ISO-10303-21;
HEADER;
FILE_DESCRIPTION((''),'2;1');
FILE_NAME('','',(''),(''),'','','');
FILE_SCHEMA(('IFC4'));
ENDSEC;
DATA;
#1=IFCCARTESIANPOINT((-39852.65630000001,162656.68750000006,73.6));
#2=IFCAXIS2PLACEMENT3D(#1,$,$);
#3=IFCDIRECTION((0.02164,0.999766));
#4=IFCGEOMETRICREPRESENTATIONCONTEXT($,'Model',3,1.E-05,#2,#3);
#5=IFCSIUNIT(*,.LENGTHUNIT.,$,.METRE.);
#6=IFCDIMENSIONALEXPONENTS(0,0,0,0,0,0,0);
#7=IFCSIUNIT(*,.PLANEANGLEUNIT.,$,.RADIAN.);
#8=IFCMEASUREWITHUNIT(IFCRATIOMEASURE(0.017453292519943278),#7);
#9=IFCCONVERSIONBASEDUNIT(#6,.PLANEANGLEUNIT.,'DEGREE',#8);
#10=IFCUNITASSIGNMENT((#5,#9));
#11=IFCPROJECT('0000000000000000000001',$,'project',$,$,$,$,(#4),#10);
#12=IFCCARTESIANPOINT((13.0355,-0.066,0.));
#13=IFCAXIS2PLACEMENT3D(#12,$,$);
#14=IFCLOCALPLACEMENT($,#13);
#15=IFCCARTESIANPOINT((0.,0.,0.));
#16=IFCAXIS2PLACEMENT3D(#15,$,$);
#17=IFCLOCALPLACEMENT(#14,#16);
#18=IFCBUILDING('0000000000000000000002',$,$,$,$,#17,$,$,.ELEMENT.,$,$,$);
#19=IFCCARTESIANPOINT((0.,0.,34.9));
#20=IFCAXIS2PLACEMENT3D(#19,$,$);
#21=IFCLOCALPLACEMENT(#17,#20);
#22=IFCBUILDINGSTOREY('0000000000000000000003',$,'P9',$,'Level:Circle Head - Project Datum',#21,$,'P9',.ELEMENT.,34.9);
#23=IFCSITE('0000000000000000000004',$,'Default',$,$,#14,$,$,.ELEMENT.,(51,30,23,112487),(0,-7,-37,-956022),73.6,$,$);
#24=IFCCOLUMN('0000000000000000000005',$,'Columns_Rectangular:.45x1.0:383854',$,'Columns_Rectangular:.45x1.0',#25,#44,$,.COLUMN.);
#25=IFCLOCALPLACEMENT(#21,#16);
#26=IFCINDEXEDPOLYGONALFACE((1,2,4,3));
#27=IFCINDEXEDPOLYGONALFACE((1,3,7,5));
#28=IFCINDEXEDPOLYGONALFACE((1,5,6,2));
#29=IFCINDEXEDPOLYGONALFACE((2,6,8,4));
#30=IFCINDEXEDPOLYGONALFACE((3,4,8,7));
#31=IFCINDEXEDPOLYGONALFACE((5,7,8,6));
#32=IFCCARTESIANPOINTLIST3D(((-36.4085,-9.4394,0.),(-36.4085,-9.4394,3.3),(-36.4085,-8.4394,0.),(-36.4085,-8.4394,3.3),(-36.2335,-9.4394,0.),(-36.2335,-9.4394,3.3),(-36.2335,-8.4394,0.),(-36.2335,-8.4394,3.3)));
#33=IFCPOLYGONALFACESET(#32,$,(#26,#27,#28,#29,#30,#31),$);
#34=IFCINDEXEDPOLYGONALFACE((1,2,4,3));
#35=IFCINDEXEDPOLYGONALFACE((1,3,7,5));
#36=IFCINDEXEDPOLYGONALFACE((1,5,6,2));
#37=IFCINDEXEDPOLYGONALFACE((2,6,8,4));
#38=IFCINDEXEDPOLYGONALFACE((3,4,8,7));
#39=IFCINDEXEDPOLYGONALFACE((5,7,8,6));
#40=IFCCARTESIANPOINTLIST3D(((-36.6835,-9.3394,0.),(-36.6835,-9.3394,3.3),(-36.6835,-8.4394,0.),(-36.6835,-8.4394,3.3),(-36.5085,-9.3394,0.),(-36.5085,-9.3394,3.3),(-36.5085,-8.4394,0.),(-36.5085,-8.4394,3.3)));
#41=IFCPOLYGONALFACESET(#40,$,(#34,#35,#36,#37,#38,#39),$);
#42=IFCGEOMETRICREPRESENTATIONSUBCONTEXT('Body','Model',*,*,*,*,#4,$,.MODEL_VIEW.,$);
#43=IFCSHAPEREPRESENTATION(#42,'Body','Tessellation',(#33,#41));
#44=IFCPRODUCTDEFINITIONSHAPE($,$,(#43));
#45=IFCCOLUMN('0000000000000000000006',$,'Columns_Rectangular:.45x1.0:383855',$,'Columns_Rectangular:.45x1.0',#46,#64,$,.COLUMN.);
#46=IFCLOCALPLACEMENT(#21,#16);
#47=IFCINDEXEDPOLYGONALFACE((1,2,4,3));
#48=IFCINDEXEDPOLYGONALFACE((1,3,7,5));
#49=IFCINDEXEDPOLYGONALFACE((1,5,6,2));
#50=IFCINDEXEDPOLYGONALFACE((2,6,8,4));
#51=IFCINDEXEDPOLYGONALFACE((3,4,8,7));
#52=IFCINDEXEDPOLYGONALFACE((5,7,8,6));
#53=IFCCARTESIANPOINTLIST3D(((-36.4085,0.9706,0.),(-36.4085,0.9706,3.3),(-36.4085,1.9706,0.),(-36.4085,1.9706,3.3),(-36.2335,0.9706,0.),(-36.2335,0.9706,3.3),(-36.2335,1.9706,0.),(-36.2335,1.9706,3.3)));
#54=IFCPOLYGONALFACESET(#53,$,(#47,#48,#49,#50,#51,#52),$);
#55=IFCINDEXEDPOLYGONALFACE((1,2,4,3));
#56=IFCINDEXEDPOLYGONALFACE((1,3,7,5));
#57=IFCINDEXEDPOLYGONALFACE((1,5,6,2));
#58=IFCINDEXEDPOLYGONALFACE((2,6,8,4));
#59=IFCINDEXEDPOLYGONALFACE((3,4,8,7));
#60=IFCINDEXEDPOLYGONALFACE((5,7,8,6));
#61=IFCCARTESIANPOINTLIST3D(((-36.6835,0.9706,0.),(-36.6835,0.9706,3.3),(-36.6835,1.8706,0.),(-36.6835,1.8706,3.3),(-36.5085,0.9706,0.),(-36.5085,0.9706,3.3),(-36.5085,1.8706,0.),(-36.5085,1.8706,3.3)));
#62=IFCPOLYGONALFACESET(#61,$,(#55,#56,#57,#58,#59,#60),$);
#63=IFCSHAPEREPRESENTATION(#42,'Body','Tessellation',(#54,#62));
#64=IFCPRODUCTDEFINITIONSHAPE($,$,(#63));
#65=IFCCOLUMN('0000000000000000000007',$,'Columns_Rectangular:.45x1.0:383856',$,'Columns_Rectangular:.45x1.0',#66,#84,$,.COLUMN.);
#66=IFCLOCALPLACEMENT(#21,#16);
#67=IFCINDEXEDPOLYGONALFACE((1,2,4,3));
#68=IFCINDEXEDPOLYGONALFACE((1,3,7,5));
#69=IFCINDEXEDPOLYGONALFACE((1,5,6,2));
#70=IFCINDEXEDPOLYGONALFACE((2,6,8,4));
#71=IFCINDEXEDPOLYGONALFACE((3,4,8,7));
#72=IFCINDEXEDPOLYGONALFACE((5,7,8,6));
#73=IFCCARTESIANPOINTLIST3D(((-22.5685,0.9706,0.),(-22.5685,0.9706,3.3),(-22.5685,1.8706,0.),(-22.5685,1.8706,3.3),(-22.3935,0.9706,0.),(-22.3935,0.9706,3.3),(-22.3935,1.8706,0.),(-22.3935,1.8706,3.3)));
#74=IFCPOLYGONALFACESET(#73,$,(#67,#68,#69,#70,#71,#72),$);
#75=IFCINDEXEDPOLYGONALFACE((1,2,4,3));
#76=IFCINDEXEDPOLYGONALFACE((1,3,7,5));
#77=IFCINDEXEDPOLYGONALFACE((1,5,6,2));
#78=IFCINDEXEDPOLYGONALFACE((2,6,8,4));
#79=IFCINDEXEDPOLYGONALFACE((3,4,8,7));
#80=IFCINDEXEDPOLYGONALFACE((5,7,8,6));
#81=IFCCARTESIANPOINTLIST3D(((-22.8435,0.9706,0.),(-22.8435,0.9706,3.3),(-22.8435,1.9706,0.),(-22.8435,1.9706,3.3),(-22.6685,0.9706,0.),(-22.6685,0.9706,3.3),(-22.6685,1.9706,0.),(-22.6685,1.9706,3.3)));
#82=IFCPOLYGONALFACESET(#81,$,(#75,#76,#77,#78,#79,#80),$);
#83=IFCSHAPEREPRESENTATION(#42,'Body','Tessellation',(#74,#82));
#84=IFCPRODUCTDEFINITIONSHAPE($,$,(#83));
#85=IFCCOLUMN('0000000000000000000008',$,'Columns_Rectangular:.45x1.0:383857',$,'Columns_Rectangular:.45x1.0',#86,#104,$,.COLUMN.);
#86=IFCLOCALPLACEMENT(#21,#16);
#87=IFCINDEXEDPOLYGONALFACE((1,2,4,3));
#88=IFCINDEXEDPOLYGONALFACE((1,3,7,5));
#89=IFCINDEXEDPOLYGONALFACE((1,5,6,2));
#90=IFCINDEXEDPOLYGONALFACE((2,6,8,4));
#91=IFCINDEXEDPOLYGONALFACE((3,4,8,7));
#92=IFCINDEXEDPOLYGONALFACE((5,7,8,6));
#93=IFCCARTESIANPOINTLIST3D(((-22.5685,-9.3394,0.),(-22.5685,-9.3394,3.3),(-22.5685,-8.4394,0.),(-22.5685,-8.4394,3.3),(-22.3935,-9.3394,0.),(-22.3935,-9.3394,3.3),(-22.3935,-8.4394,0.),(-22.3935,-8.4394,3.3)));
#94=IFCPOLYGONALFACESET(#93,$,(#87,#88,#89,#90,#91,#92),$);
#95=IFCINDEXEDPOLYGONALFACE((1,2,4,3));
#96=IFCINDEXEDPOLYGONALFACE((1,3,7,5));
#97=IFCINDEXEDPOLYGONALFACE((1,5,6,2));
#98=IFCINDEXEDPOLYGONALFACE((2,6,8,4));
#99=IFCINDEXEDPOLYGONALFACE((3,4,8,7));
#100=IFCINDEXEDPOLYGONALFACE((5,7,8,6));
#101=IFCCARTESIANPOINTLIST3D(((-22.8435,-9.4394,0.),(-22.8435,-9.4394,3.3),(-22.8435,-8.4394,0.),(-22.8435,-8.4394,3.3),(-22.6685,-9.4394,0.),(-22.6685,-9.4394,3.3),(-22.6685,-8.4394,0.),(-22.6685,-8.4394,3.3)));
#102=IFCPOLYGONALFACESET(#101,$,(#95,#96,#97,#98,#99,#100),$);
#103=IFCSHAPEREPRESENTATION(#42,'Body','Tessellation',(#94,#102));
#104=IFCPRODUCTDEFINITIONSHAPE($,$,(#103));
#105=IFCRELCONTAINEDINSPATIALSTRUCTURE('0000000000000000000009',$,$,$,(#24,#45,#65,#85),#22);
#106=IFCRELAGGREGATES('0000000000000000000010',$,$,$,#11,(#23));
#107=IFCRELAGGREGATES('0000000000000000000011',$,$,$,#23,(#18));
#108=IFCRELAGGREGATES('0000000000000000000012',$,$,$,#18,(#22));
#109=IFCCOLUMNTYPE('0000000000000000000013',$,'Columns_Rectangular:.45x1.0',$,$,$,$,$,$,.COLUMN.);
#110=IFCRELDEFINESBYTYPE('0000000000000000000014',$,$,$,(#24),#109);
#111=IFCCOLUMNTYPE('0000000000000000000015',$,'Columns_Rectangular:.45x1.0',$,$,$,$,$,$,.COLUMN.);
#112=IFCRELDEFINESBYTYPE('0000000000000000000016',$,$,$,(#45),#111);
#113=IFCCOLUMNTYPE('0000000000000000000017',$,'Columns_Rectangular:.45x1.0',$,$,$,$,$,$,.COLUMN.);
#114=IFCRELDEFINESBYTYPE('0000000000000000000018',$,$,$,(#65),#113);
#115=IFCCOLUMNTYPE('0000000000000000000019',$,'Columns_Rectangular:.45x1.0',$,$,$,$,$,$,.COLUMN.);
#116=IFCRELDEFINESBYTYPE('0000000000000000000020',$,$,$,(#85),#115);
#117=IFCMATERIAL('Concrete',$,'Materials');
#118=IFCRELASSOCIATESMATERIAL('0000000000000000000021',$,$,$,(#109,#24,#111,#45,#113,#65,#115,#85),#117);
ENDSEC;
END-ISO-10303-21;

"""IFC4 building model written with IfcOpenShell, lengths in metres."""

from ifc_helpers import new_model, entity, si_unit, converted_unit, direction, frame, origin, place, context, subcontext, project, spatial, indexed_curve, outline, extrude, source, transform, mapped, material, type_object, type_shapes, element, save


model = new_model("IFC4")

# Units and contexts
model_context = context("Model", 3, precision=1e-05, world=frame((-39852.65630000001, 162656.68750000006, 73.6)), true_north=direction((0.02164, 0.999766)))
body_context = subcontext(model_context, "Body", "Model", "MODEL_VIEW")
ifc_project = project(units=[si_unit("LENGTHUNIT", "METRE"), converted_unit("PLANEANGLEUNIT", "DEGREE", entity("IfcRatioMeasure", 0.017453292519943278), si_unit("PLANEANGLEUNIT", "RADIAN"), dimensions=[0, 0, 0, 0, 0, 0, 0])], contexts=[model_context])

# Site, building, storey
site_placement = place(None, frame((13.0355, -0.066, 0.0)))
site = spatial("IfcSite", under=ifc_project, at=site_placement, Name="Default", CompositionType="ELEMENT", RefLatitude=(51, 30, 23, 112487), RefLongitude=(0, -7, -37, -956022), RefElevation=73.6)
building_placement = place(site_placement, origin())
building = spatial("IfcBuilding", under=site, at=building_placement, CompositionType="ELEMENT")
storey_placement = place(building_placement, frame((0.0, 0.0, 34.9)))
storey = spatial("IfcBuildingStorey", under=building, at=storey_placement, Name="P9", ObjectType="Level:Circle Head - Project Datum", LongName="P9", CompositionType="ELEMENT", Elevation=34.9)

# Columns
ifc_material = material(Name="Concrete", Category="Materials")
column_type_1 = type_object("IfcColumnType", Name="Columns_Rectangular:.45x1.0", PredefinedType="COLUMN", material=ifc_material)
shared_shape_1 = source(origin(), body_context, "Body", "SweptSolid", [
    extrude(outline(indexed_curve([(-0.5, -0.0875), (0.5, -0.0875), (0.5, 0.0875), (-0.5, 0.0875), (-0.5, -0.0875)], self_intersect=False)), frame((-36.321, -8.9394, 34.9), z_axis=(0.0, 0.0, 1.0), x_axis=(0.0, -1.0, 0.0)), (0.0, 0.0, 1.0), 3.3),
    extrude(outline(indexed_curve([(-0.45, -0.0875), (0.45, -0.0875), (0.45, 0.0875), (-0.45, 0.0875), (-0.45, -0.0875)], self_intersect=False)), frame((-36.596, -8.8894, 34.9), z_axis=(0.0, 0.0, 1.0), x_axis=(0.0, -1.0, 0.0)), (0.0, 0.0, 1.0), 3.3),
])
type_shapes(column_type_1, [shared_shape_1])
column_1_placement = place(storey_placement, frame((0.0, 0.0, -34.9)))
element("IfcColumn", 1, at=column_1_placement, inside=storey, type_object=column_type_1, material=ifc_material, Name="Columns_Rectangular:.45x1.0:383854", ObjectType="Columns_Rectangular:.45x1.0", PredefinedType="COLUMN", context=body_context, shape_type="MappedRepresentation", body=[
    mapped(shared_shape_1, transform((0.0, 0.0, 0.0), scale=1.0)),
])
column_type_2 = type_object("IfcColumnType", Name="Columns_Rectangular:.45x1.0", PredefinedType="COLUMN", material=ifc_material)
shared_shape_2 = source(origin(), body_context, "Body", "SweptSolid", [
    extrude(outline(indexed_curve([(-0.5, -0.0875), (0.5, -0.0875), (0.5, 0.0875), (-0.5, 0.0875), (-0.5, -0.0875)], self_intersect=False)), frame((-36.321, 1.4706, 34.9), z_axis=(0.0, 0.0, 1.0), x_axis=(0.0, -1.0, 0.0)), (0.0, 0.0, 1.0), 3.3),
    extrude(outline(indexed_curve([(-0.45, -0.0875), (0.45, -0.0875), (0.45, 0.0875), (-0.45, 0.0875), (-0.45, -0.0875)], self_intersect=False)), frame((-36.596, 1.4206, 34.9), z_axis=(0.0, 0.0, 1.0), x_axis=(0.0, -1.0, 0.0)), (0.0, 0.0, 1.0), 3.3),
])
type_shapes(column_type_2, [shared_shape_2])
column_2_placement = place(storey_placement, frame((0.0, 0.0, -34.9)))
element("IfcColumn", 2, at=column_2_placement, inside=storey, type_object=column_type_2, material=ifc_material, Name="Columns_Rectangular:.45x1.0:383855", ObjectType="Columns_Rectangular:.45x1.0", PredefinedType="COLUMN", context=body_context, shape_type="MappedRepresentation", body=[
    mapped(shared_shape_2, transform((0.0, 0.0, 0.0), scale=1.0)),
])
column_type_3 = type_object("IfcColumnType", Name="Columns_Rectangular:.45x1.0", PredefinedType="COLUMN", material=ifc_material)
shared_shape_3 = source(origin(), body_context, "Body", "SweptSolid", [
    extrude(outline(indexed_curve([(-0.45, -0.0875), (0.45, -0.0875), (0.45, 0.0875), (-0.45, 0.0875), (-0.45, -0.0875)], self_intersect=False)), frame((-22.481, 1.4206, 34.9), z_axis=(0.0, 0.0, 1.0), x_axis=(0.0, -1.0, 0.0)), (0.0, 0.0, 1.0), 3.3),
    extrude(outline(indexed_curve([(-0.5, -0.0875), (0.5, -0.0875), (0.5, 0.0875), (-0.5, 0.0875), (-0.5, -0.0875)], self_intersect=False)), frame((-22.756, 1.4706, 34.9), z_axis=(0.0, 0.0, 1.0), x_axis=(0.0, -1.0, 0.0)), (0.0, 0.0, 1.0), 3.3),
])
type_shapes(column_type_3, [shared_shape_3])
column_3_placement = place(storey_placement, frame((0.0, 0.0, -34.9)))
element("IfcColumn", 3, at=column_3_placement, inside=storey, type_object=column_type_3, material=ifc_material, Name="Columns_Rectangular:.45x1.0:383856", ObjectType="Columns_Rectangular:.45x1.0", PredefinedType="COLUMN", context=body_context, shape_type="MappedRepresentation", body=[
    mapped(shared_shape_3, transform((0.0, 0.0, 0.0), scale=1.0)),
])
column_type_4 = type_object("IfcColumnType", Name="Columns_Rectangular:.45x1.0", PredefinedType="COLUMN", material=ifc_material)
shared_shape_4 = source(origin(), body_context, "Body", "SweptSolid", [
    extrude(outline(indexed_curve([(-0.45, -0.0875), (0.45, -0.0875), (0.45, 0.0875), (-0.45, 0.0875), (-0.45, -0.0875)], self_intersect=False)), frame((-22.481, -8.8894, 34.9), z_axis=(0.0, 0.0, 1.0), x_axis=(0.0, -1.0, 0.0)), (0.0, 0.0, 1.0), 3.3),
    extrude(outline(indexed_curve([(-0.5, -0.0875), (0.5, -0.0875), (0.5, 0.0875), (-0.5, 0.0875), (-0.5, -0.0875)], self_intersect=False)), frame((-22.756, -8.9394, 34.9), z_axis=(0.0, 0.0, 1.0), x_axis=(0.0, -1.0, 0.0)), (0.0, 0.0, 1.0), 3.3),
])
type_shapes(column_type_4, [shared_shape_4])
column_4_placement = place(storey_placement, frame((0.0, 0.0, -34.9)))
element("IfcColumn", 4, at=column_4_placement, inside=storey, type_object=column_type_4, material=ifc_material, Name="Columns_Rectangular:.45x1.0:383857", ObjectType="Columns_Rectangular:.45x1.0", PredefinedType="COLUMN", context=body_context, shape_type="MappedRepresentation", body=[
    mapped(shared_shape_4, transform((0.0, 0.0, 0.0), scale=1.0)),
])

save(model, "model.ifc")
